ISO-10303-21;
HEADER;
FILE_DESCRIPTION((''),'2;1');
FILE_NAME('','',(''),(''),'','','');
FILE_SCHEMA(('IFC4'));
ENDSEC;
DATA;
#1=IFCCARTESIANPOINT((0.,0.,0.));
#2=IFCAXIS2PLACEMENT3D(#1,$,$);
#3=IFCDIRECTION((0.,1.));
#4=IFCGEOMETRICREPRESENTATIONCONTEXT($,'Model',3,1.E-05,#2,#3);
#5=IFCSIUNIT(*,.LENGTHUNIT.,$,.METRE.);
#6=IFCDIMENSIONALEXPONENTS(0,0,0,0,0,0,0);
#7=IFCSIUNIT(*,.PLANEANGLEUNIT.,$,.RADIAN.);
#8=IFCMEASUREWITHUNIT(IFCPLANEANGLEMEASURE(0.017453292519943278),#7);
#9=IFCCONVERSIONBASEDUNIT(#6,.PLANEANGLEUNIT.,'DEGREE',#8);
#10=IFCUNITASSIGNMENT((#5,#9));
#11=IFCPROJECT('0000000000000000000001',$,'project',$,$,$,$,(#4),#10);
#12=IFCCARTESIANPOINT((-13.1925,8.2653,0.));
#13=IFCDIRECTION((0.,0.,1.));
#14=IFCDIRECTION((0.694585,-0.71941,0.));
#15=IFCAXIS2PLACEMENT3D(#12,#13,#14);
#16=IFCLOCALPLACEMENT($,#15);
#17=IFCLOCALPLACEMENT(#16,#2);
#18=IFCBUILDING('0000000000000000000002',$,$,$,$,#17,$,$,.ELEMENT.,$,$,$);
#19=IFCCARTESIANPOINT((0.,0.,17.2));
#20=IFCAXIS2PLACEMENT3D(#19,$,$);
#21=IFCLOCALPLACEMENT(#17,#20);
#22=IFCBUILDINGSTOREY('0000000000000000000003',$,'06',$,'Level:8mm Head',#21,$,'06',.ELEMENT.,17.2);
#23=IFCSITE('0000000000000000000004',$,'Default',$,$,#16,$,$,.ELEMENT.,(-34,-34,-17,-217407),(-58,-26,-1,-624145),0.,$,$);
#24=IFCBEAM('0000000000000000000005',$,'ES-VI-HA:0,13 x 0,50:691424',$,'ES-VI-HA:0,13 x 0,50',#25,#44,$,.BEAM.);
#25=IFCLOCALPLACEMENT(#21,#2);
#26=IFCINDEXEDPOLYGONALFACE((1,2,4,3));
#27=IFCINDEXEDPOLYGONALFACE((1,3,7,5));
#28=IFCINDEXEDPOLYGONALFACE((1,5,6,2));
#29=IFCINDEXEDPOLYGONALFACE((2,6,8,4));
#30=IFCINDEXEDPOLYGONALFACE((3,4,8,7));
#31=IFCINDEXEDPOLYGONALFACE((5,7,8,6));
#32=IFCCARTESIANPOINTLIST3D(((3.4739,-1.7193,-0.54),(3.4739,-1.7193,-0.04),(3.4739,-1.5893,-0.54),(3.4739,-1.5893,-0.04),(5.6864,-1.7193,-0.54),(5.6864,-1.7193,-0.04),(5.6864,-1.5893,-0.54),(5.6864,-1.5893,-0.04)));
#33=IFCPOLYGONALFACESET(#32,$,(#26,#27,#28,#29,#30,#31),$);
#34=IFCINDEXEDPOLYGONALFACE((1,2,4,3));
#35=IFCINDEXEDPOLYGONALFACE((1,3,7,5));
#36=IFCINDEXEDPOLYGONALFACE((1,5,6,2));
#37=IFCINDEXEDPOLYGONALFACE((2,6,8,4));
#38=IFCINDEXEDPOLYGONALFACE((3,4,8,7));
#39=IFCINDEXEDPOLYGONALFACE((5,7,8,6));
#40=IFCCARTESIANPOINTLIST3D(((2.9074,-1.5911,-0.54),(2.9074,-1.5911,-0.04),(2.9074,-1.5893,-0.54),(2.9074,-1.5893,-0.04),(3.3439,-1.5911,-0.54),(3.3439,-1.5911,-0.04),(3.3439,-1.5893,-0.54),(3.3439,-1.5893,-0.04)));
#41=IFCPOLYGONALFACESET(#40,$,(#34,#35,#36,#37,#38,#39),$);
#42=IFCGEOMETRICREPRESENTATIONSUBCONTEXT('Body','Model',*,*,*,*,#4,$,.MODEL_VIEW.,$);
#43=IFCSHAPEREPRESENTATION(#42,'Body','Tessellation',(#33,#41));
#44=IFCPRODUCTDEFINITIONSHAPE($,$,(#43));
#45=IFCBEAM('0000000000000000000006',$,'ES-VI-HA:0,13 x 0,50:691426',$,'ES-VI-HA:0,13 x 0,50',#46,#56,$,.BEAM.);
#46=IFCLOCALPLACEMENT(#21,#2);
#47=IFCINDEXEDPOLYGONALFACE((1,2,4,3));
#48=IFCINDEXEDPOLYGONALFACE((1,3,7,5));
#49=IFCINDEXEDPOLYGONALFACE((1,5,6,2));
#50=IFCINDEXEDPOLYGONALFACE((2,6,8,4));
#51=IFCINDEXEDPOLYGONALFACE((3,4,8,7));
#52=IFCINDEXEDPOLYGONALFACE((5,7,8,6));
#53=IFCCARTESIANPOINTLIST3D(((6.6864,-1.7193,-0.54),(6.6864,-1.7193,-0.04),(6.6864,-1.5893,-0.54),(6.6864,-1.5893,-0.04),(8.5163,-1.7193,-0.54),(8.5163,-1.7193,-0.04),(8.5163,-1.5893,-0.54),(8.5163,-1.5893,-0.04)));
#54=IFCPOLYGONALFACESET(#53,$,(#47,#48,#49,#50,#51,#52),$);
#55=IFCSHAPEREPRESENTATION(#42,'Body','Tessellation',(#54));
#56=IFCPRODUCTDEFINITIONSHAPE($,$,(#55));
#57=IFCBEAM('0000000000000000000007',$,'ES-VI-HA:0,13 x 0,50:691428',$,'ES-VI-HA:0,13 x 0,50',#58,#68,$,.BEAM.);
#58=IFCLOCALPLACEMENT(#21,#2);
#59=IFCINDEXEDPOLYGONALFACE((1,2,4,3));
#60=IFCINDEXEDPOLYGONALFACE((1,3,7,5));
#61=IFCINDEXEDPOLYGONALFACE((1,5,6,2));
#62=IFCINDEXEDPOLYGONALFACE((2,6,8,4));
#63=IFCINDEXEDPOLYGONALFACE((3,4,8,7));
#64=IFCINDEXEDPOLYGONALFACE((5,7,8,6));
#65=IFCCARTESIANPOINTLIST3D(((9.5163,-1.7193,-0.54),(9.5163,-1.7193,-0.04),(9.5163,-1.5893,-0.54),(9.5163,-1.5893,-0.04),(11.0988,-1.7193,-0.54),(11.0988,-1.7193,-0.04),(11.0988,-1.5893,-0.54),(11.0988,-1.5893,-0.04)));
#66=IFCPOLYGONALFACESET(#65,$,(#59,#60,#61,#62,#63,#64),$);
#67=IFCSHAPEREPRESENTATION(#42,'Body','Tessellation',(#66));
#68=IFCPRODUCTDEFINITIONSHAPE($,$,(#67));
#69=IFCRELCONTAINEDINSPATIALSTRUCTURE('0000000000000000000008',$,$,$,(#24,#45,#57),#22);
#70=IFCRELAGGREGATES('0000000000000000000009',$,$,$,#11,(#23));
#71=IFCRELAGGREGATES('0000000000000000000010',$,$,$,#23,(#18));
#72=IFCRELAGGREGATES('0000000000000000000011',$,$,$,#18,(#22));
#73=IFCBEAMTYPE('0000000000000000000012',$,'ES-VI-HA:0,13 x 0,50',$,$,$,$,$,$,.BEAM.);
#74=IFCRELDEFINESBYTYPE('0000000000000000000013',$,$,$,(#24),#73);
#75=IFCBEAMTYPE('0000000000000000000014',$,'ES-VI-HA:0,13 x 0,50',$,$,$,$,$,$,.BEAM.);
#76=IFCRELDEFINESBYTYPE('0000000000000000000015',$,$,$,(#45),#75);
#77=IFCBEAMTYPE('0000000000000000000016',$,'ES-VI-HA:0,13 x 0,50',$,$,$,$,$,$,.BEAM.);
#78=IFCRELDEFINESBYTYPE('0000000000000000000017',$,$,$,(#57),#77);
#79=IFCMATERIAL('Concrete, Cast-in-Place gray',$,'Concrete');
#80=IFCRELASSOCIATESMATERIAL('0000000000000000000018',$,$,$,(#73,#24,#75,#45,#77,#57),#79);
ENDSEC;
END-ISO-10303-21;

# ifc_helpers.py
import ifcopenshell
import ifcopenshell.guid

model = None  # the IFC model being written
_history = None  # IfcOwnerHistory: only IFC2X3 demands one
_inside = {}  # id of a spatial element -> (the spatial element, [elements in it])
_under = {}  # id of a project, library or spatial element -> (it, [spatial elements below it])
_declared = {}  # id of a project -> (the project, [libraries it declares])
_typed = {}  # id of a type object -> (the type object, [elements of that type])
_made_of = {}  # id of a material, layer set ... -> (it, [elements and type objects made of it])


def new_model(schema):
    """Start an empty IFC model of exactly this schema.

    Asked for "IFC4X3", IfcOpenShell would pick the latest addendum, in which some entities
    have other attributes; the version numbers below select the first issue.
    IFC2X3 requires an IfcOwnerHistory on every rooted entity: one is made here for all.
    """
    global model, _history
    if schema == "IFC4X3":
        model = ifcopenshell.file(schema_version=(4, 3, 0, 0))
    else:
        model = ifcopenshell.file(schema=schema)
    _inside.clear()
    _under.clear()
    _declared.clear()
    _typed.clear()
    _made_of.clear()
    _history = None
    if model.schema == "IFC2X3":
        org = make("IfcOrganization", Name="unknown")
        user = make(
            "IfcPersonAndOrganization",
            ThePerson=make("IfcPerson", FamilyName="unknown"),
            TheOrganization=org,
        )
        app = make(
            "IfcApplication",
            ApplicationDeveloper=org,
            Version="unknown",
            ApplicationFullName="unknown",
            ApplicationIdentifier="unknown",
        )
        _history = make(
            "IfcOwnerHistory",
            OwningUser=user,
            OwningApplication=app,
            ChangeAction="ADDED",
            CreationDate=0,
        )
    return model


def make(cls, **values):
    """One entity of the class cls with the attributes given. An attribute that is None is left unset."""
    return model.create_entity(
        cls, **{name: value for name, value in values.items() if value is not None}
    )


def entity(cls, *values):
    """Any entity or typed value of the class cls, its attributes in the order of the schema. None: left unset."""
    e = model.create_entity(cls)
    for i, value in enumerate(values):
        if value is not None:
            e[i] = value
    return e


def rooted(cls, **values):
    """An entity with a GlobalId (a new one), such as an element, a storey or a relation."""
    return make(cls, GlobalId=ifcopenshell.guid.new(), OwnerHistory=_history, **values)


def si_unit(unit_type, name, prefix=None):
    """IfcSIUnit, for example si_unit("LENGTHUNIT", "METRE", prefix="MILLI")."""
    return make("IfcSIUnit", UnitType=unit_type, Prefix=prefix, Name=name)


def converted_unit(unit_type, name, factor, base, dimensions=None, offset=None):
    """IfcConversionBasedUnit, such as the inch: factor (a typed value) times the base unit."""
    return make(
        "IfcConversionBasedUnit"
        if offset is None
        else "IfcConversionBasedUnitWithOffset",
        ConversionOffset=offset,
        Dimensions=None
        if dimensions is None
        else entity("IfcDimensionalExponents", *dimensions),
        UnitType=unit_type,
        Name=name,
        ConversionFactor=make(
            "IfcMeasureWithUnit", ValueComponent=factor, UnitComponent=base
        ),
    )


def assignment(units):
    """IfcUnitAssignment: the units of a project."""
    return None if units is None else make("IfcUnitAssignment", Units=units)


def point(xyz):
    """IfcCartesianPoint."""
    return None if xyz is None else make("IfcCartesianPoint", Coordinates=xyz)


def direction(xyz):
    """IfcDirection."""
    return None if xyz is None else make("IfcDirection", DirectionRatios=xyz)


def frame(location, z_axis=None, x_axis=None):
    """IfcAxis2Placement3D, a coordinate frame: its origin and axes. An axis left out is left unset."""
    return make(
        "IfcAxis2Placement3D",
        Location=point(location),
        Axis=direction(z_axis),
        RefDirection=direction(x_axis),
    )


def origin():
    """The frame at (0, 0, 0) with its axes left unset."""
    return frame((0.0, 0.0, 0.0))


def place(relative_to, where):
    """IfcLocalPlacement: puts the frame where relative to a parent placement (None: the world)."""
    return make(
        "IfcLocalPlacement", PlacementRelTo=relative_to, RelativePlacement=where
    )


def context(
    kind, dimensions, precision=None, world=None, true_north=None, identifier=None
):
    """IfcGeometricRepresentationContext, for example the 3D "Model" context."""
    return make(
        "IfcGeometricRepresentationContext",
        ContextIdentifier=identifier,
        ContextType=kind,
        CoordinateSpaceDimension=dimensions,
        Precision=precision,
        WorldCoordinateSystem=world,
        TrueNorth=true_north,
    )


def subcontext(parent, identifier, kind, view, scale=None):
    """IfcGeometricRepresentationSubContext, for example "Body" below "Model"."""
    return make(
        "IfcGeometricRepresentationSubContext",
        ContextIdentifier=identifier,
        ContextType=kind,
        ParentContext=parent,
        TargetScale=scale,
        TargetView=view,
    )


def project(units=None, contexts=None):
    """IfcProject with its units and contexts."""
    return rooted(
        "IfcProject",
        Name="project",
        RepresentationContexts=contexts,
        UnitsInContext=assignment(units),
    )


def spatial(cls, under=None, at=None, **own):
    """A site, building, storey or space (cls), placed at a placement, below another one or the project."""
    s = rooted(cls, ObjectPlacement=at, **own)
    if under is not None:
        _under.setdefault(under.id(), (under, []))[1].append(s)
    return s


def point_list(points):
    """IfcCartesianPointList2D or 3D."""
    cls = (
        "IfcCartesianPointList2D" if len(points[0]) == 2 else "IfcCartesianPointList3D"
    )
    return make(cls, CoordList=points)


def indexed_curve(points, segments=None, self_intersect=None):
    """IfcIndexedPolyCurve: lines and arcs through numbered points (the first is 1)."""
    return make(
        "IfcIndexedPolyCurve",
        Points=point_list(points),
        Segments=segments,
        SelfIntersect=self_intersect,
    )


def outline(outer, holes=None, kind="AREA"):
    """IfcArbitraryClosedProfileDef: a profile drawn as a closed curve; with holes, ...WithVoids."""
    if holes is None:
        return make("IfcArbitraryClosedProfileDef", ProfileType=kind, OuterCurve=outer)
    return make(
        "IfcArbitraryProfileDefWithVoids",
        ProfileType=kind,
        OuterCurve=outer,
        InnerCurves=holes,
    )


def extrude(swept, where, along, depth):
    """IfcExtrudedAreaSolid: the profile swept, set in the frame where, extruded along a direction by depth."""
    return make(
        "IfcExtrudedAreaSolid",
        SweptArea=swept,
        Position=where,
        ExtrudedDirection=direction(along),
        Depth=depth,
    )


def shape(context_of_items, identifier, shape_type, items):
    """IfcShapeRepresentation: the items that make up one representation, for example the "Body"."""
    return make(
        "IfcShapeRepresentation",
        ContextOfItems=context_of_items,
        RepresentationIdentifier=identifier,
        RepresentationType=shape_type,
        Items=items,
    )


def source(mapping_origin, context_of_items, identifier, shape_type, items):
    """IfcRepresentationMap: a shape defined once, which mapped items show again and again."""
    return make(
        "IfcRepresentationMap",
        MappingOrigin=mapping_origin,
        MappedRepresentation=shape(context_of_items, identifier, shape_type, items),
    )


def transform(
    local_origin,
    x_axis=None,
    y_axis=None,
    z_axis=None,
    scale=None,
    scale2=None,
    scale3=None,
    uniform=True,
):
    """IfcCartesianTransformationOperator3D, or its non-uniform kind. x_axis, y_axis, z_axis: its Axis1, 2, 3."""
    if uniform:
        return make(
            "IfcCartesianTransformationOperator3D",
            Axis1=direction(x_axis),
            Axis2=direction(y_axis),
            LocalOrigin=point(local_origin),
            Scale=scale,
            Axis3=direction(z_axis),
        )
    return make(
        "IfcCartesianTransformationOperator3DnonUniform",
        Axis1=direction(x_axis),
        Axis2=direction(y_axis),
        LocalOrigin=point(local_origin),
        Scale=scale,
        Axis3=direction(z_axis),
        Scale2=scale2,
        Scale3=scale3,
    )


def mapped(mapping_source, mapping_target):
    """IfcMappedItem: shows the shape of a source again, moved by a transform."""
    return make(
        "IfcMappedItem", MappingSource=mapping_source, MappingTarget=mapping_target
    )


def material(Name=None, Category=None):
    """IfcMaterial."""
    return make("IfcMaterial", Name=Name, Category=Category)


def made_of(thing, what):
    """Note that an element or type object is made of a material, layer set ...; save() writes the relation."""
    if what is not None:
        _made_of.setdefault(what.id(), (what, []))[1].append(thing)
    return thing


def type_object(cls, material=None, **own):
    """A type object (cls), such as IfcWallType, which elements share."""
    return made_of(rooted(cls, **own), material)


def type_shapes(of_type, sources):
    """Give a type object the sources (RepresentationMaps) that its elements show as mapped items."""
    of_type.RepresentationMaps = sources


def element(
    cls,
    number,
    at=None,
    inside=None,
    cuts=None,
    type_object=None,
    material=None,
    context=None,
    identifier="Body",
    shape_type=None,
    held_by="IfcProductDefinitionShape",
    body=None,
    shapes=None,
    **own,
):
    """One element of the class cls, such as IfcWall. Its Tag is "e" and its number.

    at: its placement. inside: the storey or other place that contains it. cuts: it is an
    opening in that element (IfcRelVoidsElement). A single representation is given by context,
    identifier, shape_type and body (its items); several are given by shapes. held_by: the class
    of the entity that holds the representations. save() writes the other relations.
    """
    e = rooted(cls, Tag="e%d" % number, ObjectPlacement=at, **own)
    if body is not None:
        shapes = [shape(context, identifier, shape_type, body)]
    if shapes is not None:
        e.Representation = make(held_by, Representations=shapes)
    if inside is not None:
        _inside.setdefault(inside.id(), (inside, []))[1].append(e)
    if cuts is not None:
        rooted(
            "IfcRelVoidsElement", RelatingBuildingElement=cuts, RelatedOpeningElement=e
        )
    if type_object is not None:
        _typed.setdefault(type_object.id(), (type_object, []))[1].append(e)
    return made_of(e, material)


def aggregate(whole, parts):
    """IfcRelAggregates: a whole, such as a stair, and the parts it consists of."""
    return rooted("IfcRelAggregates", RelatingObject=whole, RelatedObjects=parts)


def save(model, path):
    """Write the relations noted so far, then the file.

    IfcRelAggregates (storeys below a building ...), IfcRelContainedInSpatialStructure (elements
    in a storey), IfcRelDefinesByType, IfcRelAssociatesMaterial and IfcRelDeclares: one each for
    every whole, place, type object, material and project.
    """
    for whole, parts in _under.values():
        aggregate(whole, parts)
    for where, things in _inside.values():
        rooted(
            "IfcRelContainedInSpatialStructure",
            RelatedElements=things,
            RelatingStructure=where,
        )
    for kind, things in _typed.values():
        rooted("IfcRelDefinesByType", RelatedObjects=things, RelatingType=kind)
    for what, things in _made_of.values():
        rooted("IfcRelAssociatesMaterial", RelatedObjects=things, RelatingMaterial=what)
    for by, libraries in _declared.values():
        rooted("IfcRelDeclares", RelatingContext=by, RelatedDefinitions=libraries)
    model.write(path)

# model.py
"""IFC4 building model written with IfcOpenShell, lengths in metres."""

from ifc_helpers import new_model, entity, si_unit, converted_unit, direction, frame, origin, place, context, subcontext, project, spatial, indexed_curve, outline, extrude, source, transform, mapped, material, type_object, type_shapes, element, save


model = new_model("IFC4")

# Units and contexts
model_context = context("Model", 3, precision=1e-05, world=origin(), true_north=direction((0.0, 1.0)))
body_context = subcontext(model_context, "Body", "Model", "MODEL_VIEW")
ifc_project = project(units=[si_unit("LENGTHUNIT", "METRE"), converted_unit("PLANEANGLEUNIT", "DEGREE", entity("IfcPlaneAngleMeasure", 0.017453292519943278), si_unit("PLANEANGLEUNIT", "RADIAN"), dimensions=[0, 0, 0, 0, 0, 0, 0])], contexts=[model_context])

# Site, building, storey
site_placement = place(None, frame((-13.1925, 8.2653, 0.0), z_axis=(0.0, 0.0, 1.0), x_axis=(0.694585, -0.71941, 0.0)))
site = spatial("IfcSite", under=ifc_project, at=site_placement, Name="Default", CompositionType="ELEMENT", RefLatitude=(-34, -34, -17, -217407), RefLongitude=(-58, -26, -1, -624145), RefElevation=0.0)
building_placement = place(site_placement, origin())
building = spatial("IfcBuilding", under=site, at=building_placement, CompositionType="ELEMENT")
storey_placement = place(building_placement, frame((0.0, 0.0, 17.2)))
storey = spatial("IfcBuildingStorey", under=building, at=storey_placement, Name="06", ObjectType="Level:8mm Head", LongName="06", CompositionType="ELEMENT", Elevation=17.2)

# Beams
ifc_material_1 = material(Name="Concrete, Cast-in-Place gray", Category="Concrete")
beam_type_1 = type_object("IfcBeamType", Name="ES-VI-HA:0,13 x 0,50", PredefinedType="BEAM", material=ifc_material_1)
shared_shape_1 = source(origin(), body_context, "Body", "SweptSolid", [
    extrude(outline(indexed_curve([(-0.25, -0.065), (0.25, -0.065), (0.25, 0.065), (-0.25, 0.065), (-0.25, -0.065)], self_intersect=False)), frame((3.4739, -1.6543, 16.91), z_axis=(1.0, 0.0, 0.0), x_axis=(0.0, 0.0, -1.0)), (0.0, 0.0, 1.0), 2.2125),
    extrude(outline(indexed_curve([(-0.25, -0.0009), (0.25, -0.0009), (0.25, 0.0009), (-0.25, 0.0009), (-0.25, -0.0009)], self_intersect=False)), frame((2.9074, -1.5902, 16.91), z_axis=(1.0, 0.0, 0.0), x_axis=(0.0, 0.0, -1.0)), (0.0, 0.0, 1.0), 0.4365),
])
type_shapes(beam_type_1, [shared_shape_1])
beam_1_placement = place(storey_placement, frame((0.0, 0.0, -17.2)))
element("IfcBeam", 1, at=beam_1_placement, inside=storey, type_object=beam_type_1, material=ifc_material_1, Name="ES-VI-HA:0,13 x 0,50:691424", ObjectType="ES-VI-HA:0,13 x 0,50", PredefinedType="BEAM", context=body_context, shape_type="MappedRepresentation", body=[
    mapped(shared_shape_1, transform((0.0, 0.0, 0.0), scale=1.0)),
])
beam_type_2 = type_object("IfcBeamType", Name="ES-VI-HA:0,13 x 0,50", PredefinedType="BEAM", material=ifc_material_1)
shared_shape_2 = source(origin(), body_context, "Body", "SweptSolid", [
    extrude(outline(indexed_curve([(-0.25, -0.065), (0.25, -0.065), (0.25, 0.065), (-0.25, 0.065), (-0.25, -0.065)], self_intersect=False)), frame((6.6864, -1.6543, 16.91), z_axis=(1.0, 0.0, 0.0), x_axis=(0.0, 0.0, -1.0)), (0.0, 0.0, 1.0), 1.8299),
])
type_shapes(beam_type_2, [shared_shape_2])
beam_2_placement = place(storey_placement, frame((0.0, 0.0, -17.2)))
element("IfcBeam", 2, at=beam_2_placement, inside=storey, type_object=beam_type_2, material=ifc_material_1, Name="ES-VI-HA:0,13 x 0,50:691426", ObjectType="ES-VI-HA:0,13 x 0,50", PredefinedType="BEAM", context=body_context, shape_type="MappedRepresentation", body=[
    mapped(shared_shape_2, transform((0.0, 0.0, 0.0), scale=1.0)),
])
beam_type_3 = type_object("IfcBeamType", Name="ES-VI-HA:0,13 x 0,50", PredefinedType="BEAM", material=ifc_material_1)
shared_shape_3 = source(origin(), body_context, "Body", "SweptSolid", [
    extrude(outline(indexed_curve([(-0.25, -0.065), (0.25, -0.065), (0.25, 0.065), (-0.25, 0.065), (-0.25, -0.065)], self_intersect=False)), frame((9.5163, -1.6543, 16.91), z_axis=(1.0, 0.0, 0.0), x_axis=(0.0, 0.0, -1.0)), (0.0, 0.0, 1.0), 1.5825),
])
type_shapes(beam_type_3, [shared_shape_3])
beam_3_placement = place(storey_placement, frame((0.0, 0.0, -17.2)))
element("IfcBeam", 3, at=beam_3_placement, inside=storey, type_object=beam_type_3, material=ifc_material_1, Name="ES-VI-HA:0,13 x 0,50:691428", ObjectType="ES-VI-HA:0,13 x 0,50", PredefinedType="BEAM", context=body_context, shape_type="MappedRepresentation", body=[
    mapped(shared_shape_3, transform((0.0, 0.0, 0.0), scale=1.0)),
])

save(model, "model.ifc")
